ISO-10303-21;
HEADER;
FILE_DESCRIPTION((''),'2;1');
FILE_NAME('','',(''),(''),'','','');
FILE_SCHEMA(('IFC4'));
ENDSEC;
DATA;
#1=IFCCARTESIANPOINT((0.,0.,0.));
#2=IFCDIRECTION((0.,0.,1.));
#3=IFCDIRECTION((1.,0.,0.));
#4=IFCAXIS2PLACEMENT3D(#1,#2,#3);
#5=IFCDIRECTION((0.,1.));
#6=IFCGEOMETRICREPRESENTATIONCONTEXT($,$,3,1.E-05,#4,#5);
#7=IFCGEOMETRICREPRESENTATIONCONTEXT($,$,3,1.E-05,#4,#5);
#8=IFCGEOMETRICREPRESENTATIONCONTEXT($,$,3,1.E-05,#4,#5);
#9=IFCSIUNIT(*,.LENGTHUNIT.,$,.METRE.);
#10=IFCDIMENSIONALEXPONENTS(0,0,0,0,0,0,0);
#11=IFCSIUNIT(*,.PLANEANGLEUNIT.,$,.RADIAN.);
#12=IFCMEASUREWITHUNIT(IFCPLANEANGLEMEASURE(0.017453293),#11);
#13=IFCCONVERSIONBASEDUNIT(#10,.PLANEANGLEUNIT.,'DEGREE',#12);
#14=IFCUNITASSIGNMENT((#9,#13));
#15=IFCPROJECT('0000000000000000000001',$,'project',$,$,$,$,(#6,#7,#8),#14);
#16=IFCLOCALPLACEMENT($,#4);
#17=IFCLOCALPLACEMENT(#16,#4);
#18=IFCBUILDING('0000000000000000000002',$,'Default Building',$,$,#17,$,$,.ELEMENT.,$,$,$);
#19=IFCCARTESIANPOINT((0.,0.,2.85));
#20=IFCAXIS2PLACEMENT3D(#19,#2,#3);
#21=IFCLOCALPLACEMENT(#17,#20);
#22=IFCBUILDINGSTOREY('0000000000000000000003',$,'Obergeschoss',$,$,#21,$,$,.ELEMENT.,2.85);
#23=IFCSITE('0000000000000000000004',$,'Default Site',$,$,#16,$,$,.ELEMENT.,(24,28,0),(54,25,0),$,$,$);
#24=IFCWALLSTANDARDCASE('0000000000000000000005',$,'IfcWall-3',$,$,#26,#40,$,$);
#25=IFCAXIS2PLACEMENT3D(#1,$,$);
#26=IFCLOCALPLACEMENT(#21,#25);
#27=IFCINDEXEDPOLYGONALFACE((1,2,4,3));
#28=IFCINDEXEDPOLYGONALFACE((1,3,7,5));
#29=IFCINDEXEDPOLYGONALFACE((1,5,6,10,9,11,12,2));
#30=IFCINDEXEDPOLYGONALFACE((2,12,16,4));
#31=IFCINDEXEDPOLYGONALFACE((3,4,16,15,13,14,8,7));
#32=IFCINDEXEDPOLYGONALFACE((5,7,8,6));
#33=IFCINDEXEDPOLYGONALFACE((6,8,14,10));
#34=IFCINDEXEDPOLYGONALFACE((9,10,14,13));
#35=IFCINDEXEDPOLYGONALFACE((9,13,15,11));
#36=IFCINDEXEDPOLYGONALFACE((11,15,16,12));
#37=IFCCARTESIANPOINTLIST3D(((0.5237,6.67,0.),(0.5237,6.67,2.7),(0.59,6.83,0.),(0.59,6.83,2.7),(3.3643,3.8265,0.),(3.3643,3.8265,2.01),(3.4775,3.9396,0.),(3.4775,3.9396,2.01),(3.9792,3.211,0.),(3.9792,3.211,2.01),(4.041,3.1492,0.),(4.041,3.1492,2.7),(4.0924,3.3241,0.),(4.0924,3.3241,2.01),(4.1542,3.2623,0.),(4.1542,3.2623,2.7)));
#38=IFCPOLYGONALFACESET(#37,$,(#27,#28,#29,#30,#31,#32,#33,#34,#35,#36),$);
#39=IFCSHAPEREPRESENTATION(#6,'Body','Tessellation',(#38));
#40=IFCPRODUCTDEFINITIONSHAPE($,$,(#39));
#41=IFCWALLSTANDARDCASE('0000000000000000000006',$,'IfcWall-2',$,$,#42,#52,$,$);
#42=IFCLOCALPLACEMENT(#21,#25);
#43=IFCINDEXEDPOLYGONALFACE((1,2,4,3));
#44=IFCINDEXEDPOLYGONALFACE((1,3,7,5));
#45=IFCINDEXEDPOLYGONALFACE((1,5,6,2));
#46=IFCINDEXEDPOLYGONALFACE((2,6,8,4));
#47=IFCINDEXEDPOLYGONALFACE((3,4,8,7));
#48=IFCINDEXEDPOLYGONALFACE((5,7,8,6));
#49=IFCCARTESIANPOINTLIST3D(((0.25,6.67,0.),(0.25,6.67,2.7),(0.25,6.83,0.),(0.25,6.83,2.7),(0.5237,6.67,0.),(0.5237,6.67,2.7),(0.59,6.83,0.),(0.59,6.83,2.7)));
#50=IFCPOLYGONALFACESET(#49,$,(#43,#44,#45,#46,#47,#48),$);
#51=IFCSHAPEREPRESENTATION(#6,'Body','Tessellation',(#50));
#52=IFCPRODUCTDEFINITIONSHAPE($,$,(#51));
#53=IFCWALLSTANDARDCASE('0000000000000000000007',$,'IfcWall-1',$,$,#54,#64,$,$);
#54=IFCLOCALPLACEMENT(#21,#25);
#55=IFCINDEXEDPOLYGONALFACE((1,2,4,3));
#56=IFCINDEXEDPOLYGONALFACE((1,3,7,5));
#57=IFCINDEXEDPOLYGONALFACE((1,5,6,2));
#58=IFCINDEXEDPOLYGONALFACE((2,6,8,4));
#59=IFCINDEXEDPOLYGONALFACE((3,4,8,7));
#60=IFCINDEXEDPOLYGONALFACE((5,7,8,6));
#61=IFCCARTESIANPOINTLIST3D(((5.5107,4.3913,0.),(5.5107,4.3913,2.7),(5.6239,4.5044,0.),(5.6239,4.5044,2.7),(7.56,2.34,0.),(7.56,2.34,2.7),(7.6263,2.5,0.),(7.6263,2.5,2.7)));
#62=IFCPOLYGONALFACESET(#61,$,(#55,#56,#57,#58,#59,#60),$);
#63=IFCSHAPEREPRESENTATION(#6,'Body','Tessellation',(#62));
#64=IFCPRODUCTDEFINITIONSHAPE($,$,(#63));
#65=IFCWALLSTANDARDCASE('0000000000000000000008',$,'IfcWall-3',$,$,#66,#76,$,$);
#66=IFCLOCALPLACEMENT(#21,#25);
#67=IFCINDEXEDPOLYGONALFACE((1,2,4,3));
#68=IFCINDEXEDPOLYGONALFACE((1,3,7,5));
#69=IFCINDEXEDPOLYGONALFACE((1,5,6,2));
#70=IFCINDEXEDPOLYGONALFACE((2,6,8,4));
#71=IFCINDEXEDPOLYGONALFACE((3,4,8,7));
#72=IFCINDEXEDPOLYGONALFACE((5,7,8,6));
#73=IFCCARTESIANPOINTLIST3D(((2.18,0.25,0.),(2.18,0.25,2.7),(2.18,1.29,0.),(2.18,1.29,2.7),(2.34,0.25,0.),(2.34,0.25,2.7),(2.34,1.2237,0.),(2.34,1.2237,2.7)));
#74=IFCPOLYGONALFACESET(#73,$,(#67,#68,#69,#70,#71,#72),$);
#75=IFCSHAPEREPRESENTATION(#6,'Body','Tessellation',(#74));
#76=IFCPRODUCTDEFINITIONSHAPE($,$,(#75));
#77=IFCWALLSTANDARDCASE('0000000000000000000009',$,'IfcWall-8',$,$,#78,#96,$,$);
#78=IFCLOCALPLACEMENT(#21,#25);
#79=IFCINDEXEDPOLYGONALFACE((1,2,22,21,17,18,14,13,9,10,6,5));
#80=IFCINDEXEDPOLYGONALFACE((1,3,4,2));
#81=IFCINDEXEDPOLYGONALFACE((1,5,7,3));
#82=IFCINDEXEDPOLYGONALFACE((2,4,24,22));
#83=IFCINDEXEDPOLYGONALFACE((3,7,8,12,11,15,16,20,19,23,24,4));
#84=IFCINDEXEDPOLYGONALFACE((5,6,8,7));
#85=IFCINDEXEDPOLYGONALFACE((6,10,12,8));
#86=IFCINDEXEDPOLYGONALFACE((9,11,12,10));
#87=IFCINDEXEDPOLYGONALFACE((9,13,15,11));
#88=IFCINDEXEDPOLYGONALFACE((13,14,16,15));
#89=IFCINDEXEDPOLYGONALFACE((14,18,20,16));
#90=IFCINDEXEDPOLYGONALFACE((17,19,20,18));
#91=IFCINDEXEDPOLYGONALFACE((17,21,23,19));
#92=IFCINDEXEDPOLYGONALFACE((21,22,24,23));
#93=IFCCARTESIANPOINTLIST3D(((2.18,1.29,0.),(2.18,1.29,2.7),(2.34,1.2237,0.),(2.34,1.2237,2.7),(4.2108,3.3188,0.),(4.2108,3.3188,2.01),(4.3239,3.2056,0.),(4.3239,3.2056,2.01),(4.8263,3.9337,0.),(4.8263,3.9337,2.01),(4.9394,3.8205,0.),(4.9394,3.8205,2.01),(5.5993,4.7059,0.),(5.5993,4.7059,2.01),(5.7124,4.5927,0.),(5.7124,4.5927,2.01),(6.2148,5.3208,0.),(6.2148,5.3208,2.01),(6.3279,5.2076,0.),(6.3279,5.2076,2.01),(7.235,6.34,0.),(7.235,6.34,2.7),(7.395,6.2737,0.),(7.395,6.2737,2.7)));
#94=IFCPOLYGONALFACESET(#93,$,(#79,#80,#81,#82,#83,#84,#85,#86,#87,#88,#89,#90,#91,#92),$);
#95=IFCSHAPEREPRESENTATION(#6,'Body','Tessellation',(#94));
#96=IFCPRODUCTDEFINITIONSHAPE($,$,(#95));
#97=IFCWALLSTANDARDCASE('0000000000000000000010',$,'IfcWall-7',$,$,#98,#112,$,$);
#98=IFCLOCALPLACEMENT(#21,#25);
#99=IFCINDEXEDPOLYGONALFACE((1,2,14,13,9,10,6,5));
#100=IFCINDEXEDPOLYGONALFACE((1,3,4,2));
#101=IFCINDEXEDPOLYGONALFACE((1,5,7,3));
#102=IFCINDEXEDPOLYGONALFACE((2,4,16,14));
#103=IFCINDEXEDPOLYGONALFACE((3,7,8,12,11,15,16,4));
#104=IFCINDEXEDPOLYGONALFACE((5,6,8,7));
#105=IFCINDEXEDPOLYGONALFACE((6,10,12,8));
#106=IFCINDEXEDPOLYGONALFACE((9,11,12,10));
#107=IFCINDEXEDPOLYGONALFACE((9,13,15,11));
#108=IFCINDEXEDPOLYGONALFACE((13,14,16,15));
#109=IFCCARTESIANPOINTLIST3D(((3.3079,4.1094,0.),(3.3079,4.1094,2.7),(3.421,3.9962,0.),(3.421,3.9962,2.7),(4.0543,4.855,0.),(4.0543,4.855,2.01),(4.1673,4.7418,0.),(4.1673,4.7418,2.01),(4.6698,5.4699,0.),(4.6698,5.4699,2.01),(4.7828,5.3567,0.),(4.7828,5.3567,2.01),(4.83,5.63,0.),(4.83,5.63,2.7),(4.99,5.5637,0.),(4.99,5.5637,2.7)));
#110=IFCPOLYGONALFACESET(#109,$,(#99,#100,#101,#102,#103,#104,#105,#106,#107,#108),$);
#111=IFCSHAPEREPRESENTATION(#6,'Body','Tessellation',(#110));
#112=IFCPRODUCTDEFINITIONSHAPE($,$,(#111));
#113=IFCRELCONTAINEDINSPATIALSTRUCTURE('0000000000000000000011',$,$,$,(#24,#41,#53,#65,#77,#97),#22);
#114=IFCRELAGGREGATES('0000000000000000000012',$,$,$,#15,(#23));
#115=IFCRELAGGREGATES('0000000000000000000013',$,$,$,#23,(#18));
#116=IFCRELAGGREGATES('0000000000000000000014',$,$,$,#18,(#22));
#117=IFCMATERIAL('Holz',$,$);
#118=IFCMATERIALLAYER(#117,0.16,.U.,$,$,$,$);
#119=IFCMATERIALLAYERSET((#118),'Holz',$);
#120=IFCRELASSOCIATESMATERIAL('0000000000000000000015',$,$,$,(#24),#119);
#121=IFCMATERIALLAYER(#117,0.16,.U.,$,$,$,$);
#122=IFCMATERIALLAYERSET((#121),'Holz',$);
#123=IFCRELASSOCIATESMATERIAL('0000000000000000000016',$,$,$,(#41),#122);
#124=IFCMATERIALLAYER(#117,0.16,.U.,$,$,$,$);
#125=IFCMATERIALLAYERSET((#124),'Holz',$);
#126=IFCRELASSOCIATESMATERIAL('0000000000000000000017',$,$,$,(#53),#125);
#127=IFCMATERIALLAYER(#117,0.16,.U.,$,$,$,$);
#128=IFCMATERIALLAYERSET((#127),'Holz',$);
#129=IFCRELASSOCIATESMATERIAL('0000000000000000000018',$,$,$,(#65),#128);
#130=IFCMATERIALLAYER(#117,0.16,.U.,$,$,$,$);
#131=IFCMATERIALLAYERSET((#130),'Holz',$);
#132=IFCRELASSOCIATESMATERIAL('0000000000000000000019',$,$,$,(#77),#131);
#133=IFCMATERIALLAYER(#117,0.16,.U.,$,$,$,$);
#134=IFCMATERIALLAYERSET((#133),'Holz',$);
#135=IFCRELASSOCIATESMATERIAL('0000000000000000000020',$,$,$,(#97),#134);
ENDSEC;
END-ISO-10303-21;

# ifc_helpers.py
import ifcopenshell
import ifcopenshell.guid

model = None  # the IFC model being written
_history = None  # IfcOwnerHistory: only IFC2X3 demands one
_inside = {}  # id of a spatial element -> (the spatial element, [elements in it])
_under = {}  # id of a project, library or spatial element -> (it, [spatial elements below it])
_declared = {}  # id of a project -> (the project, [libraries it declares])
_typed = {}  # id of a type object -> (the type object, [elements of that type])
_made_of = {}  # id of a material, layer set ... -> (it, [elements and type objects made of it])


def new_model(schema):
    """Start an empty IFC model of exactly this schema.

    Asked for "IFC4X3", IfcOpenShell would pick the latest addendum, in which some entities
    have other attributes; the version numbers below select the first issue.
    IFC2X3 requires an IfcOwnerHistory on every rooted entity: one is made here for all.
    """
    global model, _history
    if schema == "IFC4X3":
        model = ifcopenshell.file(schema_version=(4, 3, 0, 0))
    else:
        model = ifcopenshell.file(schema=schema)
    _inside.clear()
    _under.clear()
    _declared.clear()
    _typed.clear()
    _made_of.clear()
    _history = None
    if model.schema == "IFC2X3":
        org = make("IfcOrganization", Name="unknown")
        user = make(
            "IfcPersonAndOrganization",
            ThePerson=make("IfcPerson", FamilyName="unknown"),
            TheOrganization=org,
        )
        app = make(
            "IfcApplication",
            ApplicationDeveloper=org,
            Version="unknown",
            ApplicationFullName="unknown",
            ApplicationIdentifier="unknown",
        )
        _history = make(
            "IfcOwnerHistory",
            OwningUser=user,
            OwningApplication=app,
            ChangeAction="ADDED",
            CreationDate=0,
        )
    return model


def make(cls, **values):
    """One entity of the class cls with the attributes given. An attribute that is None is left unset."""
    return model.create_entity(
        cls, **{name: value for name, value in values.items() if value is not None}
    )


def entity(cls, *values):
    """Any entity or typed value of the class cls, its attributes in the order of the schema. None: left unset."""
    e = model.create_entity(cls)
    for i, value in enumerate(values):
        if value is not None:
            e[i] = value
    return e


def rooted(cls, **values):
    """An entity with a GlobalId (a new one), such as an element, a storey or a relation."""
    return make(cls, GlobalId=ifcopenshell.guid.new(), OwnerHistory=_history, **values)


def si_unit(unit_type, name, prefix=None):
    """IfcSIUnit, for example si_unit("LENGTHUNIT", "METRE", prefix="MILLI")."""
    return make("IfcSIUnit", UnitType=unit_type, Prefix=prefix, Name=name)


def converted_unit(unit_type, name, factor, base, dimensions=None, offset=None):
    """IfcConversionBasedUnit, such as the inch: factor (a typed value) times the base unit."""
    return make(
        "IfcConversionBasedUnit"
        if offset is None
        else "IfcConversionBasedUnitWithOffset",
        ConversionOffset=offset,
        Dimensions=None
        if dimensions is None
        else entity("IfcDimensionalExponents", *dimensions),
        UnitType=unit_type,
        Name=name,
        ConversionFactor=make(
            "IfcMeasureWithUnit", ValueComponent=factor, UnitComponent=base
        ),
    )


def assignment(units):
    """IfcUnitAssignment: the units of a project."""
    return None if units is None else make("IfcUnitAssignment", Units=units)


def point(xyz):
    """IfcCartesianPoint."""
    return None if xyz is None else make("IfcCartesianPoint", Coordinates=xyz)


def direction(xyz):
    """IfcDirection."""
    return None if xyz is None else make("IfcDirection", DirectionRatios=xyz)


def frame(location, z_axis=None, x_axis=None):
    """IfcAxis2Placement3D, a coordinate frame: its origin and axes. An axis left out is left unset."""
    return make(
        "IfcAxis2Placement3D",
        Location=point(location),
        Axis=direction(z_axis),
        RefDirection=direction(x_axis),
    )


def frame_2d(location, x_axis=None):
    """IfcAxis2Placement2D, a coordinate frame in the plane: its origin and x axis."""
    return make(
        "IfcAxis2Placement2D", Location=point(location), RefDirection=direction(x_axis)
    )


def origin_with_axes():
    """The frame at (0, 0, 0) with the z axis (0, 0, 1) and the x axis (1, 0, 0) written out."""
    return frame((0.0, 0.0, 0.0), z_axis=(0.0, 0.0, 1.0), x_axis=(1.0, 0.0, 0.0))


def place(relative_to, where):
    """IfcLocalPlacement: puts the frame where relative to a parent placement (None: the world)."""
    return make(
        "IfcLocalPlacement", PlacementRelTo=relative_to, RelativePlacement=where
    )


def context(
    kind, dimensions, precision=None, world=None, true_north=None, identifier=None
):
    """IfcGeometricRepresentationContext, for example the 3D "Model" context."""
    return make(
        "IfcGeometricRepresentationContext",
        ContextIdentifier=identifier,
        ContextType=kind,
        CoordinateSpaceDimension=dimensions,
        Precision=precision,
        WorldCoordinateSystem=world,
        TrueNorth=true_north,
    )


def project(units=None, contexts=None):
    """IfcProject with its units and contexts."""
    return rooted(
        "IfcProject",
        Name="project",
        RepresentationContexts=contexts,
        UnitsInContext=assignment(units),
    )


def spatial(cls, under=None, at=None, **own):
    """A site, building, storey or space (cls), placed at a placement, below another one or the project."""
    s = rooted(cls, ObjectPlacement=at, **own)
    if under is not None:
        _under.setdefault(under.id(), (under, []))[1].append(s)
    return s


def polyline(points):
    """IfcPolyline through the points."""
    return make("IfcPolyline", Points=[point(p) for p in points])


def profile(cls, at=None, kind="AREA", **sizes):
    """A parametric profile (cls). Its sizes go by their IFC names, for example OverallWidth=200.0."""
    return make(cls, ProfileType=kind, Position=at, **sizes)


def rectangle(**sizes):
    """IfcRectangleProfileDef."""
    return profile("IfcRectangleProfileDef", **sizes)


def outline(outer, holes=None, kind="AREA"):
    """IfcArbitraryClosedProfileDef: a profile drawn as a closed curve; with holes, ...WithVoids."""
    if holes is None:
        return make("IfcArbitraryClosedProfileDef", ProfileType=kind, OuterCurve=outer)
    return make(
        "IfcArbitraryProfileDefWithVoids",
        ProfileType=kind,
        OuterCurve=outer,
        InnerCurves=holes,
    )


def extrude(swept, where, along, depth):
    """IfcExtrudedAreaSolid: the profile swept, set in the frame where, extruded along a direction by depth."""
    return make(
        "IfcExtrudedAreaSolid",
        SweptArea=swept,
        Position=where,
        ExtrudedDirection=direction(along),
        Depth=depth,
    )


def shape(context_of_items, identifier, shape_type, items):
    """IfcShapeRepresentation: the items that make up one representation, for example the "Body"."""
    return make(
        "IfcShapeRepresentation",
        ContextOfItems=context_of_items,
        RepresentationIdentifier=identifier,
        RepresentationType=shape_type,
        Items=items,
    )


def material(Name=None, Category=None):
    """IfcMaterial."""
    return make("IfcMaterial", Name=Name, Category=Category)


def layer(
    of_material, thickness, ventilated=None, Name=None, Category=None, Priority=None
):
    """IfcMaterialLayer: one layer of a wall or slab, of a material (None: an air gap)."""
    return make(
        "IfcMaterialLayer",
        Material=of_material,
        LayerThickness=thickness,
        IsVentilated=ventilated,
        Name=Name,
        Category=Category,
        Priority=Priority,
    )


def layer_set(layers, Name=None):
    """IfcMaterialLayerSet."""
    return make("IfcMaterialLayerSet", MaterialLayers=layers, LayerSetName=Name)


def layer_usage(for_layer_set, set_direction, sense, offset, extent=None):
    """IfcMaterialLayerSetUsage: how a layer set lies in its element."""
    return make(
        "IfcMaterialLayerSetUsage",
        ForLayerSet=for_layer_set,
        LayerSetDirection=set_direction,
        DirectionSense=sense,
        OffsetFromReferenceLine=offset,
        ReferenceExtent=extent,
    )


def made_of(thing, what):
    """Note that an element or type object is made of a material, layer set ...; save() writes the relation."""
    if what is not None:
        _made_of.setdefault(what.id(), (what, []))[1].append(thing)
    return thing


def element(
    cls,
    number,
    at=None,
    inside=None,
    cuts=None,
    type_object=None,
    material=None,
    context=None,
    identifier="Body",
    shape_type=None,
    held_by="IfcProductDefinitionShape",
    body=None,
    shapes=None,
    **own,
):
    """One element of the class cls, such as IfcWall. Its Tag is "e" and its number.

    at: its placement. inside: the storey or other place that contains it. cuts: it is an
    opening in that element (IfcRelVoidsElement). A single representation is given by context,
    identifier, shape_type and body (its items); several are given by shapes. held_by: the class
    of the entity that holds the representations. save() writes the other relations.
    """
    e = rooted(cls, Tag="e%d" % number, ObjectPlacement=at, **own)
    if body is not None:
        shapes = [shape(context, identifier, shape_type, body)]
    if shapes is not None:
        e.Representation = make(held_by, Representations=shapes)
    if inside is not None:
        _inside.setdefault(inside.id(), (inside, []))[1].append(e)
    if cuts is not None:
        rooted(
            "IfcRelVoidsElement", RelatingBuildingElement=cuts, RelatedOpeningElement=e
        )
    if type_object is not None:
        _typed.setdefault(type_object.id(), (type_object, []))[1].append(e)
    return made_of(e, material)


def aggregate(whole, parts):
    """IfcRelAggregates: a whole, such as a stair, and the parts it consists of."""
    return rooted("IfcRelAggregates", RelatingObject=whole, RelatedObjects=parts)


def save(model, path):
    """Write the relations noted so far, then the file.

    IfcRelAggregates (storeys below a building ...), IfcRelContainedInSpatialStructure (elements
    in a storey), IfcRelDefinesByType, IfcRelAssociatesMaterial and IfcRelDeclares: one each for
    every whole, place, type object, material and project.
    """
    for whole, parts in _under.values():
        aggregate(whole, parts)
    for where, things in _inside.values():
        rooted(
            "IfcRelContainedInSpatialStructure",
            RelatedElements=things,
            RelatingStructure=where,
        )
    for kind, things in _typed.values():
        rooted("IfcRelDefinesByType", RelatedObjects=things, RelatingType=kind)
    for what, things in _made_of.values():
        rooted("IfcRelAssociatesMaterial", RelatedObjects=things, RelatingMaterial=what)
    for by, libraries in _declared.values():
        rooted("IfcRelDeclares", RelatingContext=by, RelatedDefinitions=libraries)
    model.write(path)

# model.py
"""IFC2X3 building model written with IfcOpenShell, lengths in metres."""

from ifc_helpers import new_model, entity, si_unit, converted_unit, direction, frame, frame_2d, origin_with_axes, place, context, project, spatial, polyline, rectangle, outline, extrude, material, layer, layer_set, layer_usage, element, save


model = new_model("IFC2X3")

# Units and contexts
context_of_model_1 = context(None, 3, precision=1e-05, world=origin_with_axes(), true_north=direction((0.0, 1.0)))
context_of_model_2 = context(None, 3, precision=1e-05, world=origin_with_axes(), true_north=direction((0.0, 1.0)))
context_of_model_3 = context(None, 3, precision=1e-05, world=origin_with_axes(), true_north=direction((0.0, 1.0)))
ifc_project = project(units=[si_unit("LENGTHUNIT", "METRE"), converted_unit("PLANEANGLEUNIT", "DEGREE", entity("IfcPlaneAngleMeasure", 0.017453293), si_unit("PLANEANGLEUNIT", "RADIAN"), dimensions=[0, 0, 0, 0, 0, 0, 0])], contexts=[context_of_model_1, context_of_model_2, context_of_model_3])

# Site, building, storey
site_placement = place(None, origin_with_axes())
site = spatial("IfcSite", under=ifc_project, at=site_placement, Name="Default Site", CompositionType="ELEMENT", RefLatitude=(24, 28, 0), RefLongitude=(54, 25, 0))
building_placement = place(site_placement, origin_with_axes())
building = spatial("IfcBuilding", under=site, at=building_placement, Name="Default Building", CompositionType="ELEMENT")
storey_placement = place(building_placement, frame((0.0, 0.0, 2.85), z_axis=(0.0, 0.0, 1.0), x_axis=(1.0, 0.0, 0.0)))
storey = spatial("IfcBuildingStorey", under=building, at=storey_placement, Name="Obergeschoss", CompositionType="ELEMENT", Elevation=2.85)

# Shared definitions
ifc_material_1 = material(Name="Holz")

# Wall, opening
ifc_layer_1 = layer(ifc_material_1, 0.16, ventilated="UNKNOWN")
ifc_layer_set_1 = layer_set([ifc_layer_1], Name="Holz")
ifc_layer_usage_1 = layer_usage(ifc_layer_set_1, "AXIS2", "NEGATIVE", 0.0)
wall_1_placement = place(storey_placement, frame((0.59, 6.83, 0.0), z_axis=(0.0, 0.0, 1.0), x_axis=(0.706757, -0.707457, 0.0)))
wall_1 = element("IfcWallStandardCase", 1, at=wall_1_placement, inside=storey, material=ifc_layer_usage_1, Name="IfcWall-3", context=context_of_model_1, shape_type="SweptSolid", body=[
    extrude(outline(polyline([(0.0663, -0.16), (5.0431, -0.16), (5.0431, 0.0), (0.0, 0.0), (0.0663, -0.16)])), origin_with_axes(), (0.0, 0.0, 1.0), 2.7),
])
opening_1_placement = place(wall_1_placement, frame((4.5206, -0.16, 0.0), z_axis=(0.0, 0.0, 1.0), x_axis=(1.0, 0.0, 0.0)))
element("IfcOpeningElement", 2, at=opening_1_placement, cuts=wall_1, context=context_of_model_1, shape_type="SweptSolid", body=[
    extrude(rectangle(XDim=2.01, YDim=0.87, at=frame_2d((0.0, 1.005), x_axis=(0.0, -1.0))), frame((0.0, 0.0, 0.0), z_axis=(0.0, 1.0, 0.0), x_axis=(-1.0, 0.0, 0.0)), (0.0, 0.0, 1.0), 0.16),
])

# Walls
ifc_layer_2 = layer(ifc_material_1, 0.16, ventilated="UNKNOWN")
ifc_layer_set_2 = layer_set([ifc_layer_2], Name="Holz")
ifc_layer_usage_2 = layer_usage(ifc_layer_set_2, "AXIS2", "NEGATIVE", 0.0)
wall_2_placement = place(storey_placement, frame((0.0, 6.83, 0.0), z_axis=(0.0, 0.0, 1.0), x_axis=(1.0, 0.0, 0.0)))
element("IfcWallStandardCase", 3, at=wall_2_placement, inside=storey, material=ifc_layer_usage_2, Name="IfcWall-2", context=context_of_model_1, shape_type="SweptSolid", body=[
    extrude(outline(polyline([(0.25, -0.16), (0.5237, -0.16), (0.59, 0.0), (0.25, 0.0), (0.25, -0.16)])), origin_with_axes(), (0.0, 0.0, 1.0), 2.7),
])
ifc_layer_3 = layer(ifc_material_1, 0.16, ventilated="UNKNOWN")
ifc_layer_set_3 = layer_set([ifc_layer_3], Name="Holz")
ifc_layer_usage_3 = layer_usage(ifc_layer_set_3, "AXIS2", "NEGATIVE", 0.0)
wall_3_placement = place(storey_placement, frame((7.56, 2.34, 0.0), z_axis=(0.0, 0.0, 1.0), x_axis=(-0.706757, 0.707457, 0.0)))
element("IfcWallStandardCase", 4, at=wall_3_placement, inside=storey, material=ifc_layer_usage_3, Name="IfcWall-1", context=context_of_model_1, shape_type="SweptSolid", body=[
    extrude(outline(polyline([(0.0663, -0.16), (2.8995, -0.16), (2.8995, 0.0), (0.0, 0.0), (0.0663, -0.16)])), origin_with_axes(), (0.0, 0.0, 1.0), 2.7),
])
ifc_layer_4 = layer(ifc_material_1, 0.16, ventilated="UNKNOWN")
ifc_layer_set_4 = layer_set([ifc_layer_4], Name="Holz")
ifc_layer_usage_4 = layer_usage(ifc_layer_set_4, "AXIS2", "NEGATIVE", 0.0)
wall_4_placement = place(storey_placement, frame((2.18, 0.0, 0.0), z_axis=(0.0, 0.0, 1.0), x_axis=(0.0, 1.0, 0.0)))
element("IfcWallStandardCase", 5, at=wall_4_placement, inside=storey, material=ifc_layer_usage_4, Name="IfcWall-3", context=context_of_model_1, shape_type="SweptSolid", body=[
    extrude(outline(polyline([(0.25, -0.16), (1.2237, -0.16), (1.29, 0.0), (0.25, 0.0), (0.25, -0.16)])), origin_with_axes(), (0.0, 0.0, 1.0), 2.7),
])

# Wall, openings
ifc_layer_5 = layer(ifc_material_1, 0.16, ventilated="UNKNOWN")
ifc_layer_set_5 = layer_set([ifc_layer_5], Name="Holz")
ifc_layer_usage_5 = layer_usage(ifc_layer_set_5, "AXIS2", "NEGATIVE", 0.0)
wall_5_placement = place(storey_placement, frame((2.18, 1.29, 0.0), z_axis=(0.0, 0.0, 1.0), x_axis=(0.707457, 0.706757, 0.0)))
wall_5 = element("IfcWallStandardCase", 6, at=wall_5_placement, inside=storey, material=ifc_layer_usage_5, Name="IfcWall-8", context=context_of_model_1, shape_type="SweptSolid", body=[
    extrude(outline(polyline([(0.0663, -0.16), (7.2116, -0.16), (7.1453, 0.0), (0.0, 0.0), (0.0663, -0.16)])), origin_with_axes(), (0.0, 0.0, 1.0), 2.7),
])
opening_2_placement = place(wall_5_placement, frame((3.3056, -0.16, 0.0), z_axis=(0.0, 0.0, 1.0), x_axis=(1.0, 0.0, 0.0)))
element("IfcOpeningElement", 7, at=opening_2_placement, cuts=wall_5, context=context_of_model_1, shape_type="SweptSolid", body=[
    extrude(rectangle(XDim=2.01, YDim=0.87, at=frame_2d((0.0, 1.005), x_axis=(0.0, -1.0))), frame((0.0, 0.0, 0.0), z_axis=(0.0, 1.0, 0.0), x_axis=(-1.0, 0.0, 0.0)), (0.0, 0.0, 1.0), 0.16),
])
opening_3_placement = place(wall_5_placement, frame((5.2682, -0.16, 0.0), z_axis=(0.0, 0.0, 1.0), x_axis=(1.0, 0.0, 0.0)))
element("IfcOpeningElement", 8, at=opening_3_placement, cuts=wall_5, context=context_of_model_1, shape_type="SweptSolid", body=[
    extrude(rectangle(XDim=2.01, YDim=0.87, at=frame_2d((0.0, 1.005), x_axis=(0.0, -1.0))), frame((0.0, 0.0, 0.0), z_axis=(0.0, 1.0, 0.0), x_axis=(-1.0, 0.0, 0.0)), (0.0, 0.0, 1.0), 0.16),
])

# Wall, opening
ifc_layer_6 = layer(ifc_material_1, 0.16, ventilated="UNKNOWN")
ifc_layer_set_6 = layer_set([ifc_layer_6], Name="Holz")
ifc_layer_usage_6 = layer_usage(ifc_layer_set_6, "AXIS2", "POSITIVE", 0.0)
wall_6_placement = place(storey_placement, frame((4.83, 5.63, 0.0), z_axis=(0.0, 0.0, 1.0), x_axis=(-0.707457, -0.706757, 0.0)))
wall_6 = element("IfcWallStandardCase", 9, at=wall_6_placement, inside=storey, material=ifc_layer_usage_6, Name="IfcWall-7", context=context_of_model_1, shape_type="SweptSolid", body=[
    extrude(outline(polyline([(0.0, 0.0), (2.1515, 0.0), (2.1515, 0.16), (-0.0663, 0.16), (0.0, 0.0)])), origin_with_axes(), (0.0, 0.0, 1.0), 2.7),
])
opening_4_placement = place(wall_6_placement, frame((0.6615, 0.0, 0.0), z_axis=(0.0, 0.0, 1.0), x_axis=(1.0, 0.0, 0.0)))
element("IfcOpeningElement", 10, at=opening_4_placement, cuts=wall_6, context=context_of_model_1, shape_type="SweptSolid", body=[
    extrude(rectangle(XDim=2.01, YDim=0.87, at=frame_2d((0.0, 1.005), x_axis=(0.0, -1.0))), frame((0.0, 0.0, 0.0), z_axis=(0.0, 1.0, 0.0), x_axis=(-1.0, 0.0, 0.0)), (0.0, 0.0, 1.0), 0.16),
])

save(model, "model.ifc")
